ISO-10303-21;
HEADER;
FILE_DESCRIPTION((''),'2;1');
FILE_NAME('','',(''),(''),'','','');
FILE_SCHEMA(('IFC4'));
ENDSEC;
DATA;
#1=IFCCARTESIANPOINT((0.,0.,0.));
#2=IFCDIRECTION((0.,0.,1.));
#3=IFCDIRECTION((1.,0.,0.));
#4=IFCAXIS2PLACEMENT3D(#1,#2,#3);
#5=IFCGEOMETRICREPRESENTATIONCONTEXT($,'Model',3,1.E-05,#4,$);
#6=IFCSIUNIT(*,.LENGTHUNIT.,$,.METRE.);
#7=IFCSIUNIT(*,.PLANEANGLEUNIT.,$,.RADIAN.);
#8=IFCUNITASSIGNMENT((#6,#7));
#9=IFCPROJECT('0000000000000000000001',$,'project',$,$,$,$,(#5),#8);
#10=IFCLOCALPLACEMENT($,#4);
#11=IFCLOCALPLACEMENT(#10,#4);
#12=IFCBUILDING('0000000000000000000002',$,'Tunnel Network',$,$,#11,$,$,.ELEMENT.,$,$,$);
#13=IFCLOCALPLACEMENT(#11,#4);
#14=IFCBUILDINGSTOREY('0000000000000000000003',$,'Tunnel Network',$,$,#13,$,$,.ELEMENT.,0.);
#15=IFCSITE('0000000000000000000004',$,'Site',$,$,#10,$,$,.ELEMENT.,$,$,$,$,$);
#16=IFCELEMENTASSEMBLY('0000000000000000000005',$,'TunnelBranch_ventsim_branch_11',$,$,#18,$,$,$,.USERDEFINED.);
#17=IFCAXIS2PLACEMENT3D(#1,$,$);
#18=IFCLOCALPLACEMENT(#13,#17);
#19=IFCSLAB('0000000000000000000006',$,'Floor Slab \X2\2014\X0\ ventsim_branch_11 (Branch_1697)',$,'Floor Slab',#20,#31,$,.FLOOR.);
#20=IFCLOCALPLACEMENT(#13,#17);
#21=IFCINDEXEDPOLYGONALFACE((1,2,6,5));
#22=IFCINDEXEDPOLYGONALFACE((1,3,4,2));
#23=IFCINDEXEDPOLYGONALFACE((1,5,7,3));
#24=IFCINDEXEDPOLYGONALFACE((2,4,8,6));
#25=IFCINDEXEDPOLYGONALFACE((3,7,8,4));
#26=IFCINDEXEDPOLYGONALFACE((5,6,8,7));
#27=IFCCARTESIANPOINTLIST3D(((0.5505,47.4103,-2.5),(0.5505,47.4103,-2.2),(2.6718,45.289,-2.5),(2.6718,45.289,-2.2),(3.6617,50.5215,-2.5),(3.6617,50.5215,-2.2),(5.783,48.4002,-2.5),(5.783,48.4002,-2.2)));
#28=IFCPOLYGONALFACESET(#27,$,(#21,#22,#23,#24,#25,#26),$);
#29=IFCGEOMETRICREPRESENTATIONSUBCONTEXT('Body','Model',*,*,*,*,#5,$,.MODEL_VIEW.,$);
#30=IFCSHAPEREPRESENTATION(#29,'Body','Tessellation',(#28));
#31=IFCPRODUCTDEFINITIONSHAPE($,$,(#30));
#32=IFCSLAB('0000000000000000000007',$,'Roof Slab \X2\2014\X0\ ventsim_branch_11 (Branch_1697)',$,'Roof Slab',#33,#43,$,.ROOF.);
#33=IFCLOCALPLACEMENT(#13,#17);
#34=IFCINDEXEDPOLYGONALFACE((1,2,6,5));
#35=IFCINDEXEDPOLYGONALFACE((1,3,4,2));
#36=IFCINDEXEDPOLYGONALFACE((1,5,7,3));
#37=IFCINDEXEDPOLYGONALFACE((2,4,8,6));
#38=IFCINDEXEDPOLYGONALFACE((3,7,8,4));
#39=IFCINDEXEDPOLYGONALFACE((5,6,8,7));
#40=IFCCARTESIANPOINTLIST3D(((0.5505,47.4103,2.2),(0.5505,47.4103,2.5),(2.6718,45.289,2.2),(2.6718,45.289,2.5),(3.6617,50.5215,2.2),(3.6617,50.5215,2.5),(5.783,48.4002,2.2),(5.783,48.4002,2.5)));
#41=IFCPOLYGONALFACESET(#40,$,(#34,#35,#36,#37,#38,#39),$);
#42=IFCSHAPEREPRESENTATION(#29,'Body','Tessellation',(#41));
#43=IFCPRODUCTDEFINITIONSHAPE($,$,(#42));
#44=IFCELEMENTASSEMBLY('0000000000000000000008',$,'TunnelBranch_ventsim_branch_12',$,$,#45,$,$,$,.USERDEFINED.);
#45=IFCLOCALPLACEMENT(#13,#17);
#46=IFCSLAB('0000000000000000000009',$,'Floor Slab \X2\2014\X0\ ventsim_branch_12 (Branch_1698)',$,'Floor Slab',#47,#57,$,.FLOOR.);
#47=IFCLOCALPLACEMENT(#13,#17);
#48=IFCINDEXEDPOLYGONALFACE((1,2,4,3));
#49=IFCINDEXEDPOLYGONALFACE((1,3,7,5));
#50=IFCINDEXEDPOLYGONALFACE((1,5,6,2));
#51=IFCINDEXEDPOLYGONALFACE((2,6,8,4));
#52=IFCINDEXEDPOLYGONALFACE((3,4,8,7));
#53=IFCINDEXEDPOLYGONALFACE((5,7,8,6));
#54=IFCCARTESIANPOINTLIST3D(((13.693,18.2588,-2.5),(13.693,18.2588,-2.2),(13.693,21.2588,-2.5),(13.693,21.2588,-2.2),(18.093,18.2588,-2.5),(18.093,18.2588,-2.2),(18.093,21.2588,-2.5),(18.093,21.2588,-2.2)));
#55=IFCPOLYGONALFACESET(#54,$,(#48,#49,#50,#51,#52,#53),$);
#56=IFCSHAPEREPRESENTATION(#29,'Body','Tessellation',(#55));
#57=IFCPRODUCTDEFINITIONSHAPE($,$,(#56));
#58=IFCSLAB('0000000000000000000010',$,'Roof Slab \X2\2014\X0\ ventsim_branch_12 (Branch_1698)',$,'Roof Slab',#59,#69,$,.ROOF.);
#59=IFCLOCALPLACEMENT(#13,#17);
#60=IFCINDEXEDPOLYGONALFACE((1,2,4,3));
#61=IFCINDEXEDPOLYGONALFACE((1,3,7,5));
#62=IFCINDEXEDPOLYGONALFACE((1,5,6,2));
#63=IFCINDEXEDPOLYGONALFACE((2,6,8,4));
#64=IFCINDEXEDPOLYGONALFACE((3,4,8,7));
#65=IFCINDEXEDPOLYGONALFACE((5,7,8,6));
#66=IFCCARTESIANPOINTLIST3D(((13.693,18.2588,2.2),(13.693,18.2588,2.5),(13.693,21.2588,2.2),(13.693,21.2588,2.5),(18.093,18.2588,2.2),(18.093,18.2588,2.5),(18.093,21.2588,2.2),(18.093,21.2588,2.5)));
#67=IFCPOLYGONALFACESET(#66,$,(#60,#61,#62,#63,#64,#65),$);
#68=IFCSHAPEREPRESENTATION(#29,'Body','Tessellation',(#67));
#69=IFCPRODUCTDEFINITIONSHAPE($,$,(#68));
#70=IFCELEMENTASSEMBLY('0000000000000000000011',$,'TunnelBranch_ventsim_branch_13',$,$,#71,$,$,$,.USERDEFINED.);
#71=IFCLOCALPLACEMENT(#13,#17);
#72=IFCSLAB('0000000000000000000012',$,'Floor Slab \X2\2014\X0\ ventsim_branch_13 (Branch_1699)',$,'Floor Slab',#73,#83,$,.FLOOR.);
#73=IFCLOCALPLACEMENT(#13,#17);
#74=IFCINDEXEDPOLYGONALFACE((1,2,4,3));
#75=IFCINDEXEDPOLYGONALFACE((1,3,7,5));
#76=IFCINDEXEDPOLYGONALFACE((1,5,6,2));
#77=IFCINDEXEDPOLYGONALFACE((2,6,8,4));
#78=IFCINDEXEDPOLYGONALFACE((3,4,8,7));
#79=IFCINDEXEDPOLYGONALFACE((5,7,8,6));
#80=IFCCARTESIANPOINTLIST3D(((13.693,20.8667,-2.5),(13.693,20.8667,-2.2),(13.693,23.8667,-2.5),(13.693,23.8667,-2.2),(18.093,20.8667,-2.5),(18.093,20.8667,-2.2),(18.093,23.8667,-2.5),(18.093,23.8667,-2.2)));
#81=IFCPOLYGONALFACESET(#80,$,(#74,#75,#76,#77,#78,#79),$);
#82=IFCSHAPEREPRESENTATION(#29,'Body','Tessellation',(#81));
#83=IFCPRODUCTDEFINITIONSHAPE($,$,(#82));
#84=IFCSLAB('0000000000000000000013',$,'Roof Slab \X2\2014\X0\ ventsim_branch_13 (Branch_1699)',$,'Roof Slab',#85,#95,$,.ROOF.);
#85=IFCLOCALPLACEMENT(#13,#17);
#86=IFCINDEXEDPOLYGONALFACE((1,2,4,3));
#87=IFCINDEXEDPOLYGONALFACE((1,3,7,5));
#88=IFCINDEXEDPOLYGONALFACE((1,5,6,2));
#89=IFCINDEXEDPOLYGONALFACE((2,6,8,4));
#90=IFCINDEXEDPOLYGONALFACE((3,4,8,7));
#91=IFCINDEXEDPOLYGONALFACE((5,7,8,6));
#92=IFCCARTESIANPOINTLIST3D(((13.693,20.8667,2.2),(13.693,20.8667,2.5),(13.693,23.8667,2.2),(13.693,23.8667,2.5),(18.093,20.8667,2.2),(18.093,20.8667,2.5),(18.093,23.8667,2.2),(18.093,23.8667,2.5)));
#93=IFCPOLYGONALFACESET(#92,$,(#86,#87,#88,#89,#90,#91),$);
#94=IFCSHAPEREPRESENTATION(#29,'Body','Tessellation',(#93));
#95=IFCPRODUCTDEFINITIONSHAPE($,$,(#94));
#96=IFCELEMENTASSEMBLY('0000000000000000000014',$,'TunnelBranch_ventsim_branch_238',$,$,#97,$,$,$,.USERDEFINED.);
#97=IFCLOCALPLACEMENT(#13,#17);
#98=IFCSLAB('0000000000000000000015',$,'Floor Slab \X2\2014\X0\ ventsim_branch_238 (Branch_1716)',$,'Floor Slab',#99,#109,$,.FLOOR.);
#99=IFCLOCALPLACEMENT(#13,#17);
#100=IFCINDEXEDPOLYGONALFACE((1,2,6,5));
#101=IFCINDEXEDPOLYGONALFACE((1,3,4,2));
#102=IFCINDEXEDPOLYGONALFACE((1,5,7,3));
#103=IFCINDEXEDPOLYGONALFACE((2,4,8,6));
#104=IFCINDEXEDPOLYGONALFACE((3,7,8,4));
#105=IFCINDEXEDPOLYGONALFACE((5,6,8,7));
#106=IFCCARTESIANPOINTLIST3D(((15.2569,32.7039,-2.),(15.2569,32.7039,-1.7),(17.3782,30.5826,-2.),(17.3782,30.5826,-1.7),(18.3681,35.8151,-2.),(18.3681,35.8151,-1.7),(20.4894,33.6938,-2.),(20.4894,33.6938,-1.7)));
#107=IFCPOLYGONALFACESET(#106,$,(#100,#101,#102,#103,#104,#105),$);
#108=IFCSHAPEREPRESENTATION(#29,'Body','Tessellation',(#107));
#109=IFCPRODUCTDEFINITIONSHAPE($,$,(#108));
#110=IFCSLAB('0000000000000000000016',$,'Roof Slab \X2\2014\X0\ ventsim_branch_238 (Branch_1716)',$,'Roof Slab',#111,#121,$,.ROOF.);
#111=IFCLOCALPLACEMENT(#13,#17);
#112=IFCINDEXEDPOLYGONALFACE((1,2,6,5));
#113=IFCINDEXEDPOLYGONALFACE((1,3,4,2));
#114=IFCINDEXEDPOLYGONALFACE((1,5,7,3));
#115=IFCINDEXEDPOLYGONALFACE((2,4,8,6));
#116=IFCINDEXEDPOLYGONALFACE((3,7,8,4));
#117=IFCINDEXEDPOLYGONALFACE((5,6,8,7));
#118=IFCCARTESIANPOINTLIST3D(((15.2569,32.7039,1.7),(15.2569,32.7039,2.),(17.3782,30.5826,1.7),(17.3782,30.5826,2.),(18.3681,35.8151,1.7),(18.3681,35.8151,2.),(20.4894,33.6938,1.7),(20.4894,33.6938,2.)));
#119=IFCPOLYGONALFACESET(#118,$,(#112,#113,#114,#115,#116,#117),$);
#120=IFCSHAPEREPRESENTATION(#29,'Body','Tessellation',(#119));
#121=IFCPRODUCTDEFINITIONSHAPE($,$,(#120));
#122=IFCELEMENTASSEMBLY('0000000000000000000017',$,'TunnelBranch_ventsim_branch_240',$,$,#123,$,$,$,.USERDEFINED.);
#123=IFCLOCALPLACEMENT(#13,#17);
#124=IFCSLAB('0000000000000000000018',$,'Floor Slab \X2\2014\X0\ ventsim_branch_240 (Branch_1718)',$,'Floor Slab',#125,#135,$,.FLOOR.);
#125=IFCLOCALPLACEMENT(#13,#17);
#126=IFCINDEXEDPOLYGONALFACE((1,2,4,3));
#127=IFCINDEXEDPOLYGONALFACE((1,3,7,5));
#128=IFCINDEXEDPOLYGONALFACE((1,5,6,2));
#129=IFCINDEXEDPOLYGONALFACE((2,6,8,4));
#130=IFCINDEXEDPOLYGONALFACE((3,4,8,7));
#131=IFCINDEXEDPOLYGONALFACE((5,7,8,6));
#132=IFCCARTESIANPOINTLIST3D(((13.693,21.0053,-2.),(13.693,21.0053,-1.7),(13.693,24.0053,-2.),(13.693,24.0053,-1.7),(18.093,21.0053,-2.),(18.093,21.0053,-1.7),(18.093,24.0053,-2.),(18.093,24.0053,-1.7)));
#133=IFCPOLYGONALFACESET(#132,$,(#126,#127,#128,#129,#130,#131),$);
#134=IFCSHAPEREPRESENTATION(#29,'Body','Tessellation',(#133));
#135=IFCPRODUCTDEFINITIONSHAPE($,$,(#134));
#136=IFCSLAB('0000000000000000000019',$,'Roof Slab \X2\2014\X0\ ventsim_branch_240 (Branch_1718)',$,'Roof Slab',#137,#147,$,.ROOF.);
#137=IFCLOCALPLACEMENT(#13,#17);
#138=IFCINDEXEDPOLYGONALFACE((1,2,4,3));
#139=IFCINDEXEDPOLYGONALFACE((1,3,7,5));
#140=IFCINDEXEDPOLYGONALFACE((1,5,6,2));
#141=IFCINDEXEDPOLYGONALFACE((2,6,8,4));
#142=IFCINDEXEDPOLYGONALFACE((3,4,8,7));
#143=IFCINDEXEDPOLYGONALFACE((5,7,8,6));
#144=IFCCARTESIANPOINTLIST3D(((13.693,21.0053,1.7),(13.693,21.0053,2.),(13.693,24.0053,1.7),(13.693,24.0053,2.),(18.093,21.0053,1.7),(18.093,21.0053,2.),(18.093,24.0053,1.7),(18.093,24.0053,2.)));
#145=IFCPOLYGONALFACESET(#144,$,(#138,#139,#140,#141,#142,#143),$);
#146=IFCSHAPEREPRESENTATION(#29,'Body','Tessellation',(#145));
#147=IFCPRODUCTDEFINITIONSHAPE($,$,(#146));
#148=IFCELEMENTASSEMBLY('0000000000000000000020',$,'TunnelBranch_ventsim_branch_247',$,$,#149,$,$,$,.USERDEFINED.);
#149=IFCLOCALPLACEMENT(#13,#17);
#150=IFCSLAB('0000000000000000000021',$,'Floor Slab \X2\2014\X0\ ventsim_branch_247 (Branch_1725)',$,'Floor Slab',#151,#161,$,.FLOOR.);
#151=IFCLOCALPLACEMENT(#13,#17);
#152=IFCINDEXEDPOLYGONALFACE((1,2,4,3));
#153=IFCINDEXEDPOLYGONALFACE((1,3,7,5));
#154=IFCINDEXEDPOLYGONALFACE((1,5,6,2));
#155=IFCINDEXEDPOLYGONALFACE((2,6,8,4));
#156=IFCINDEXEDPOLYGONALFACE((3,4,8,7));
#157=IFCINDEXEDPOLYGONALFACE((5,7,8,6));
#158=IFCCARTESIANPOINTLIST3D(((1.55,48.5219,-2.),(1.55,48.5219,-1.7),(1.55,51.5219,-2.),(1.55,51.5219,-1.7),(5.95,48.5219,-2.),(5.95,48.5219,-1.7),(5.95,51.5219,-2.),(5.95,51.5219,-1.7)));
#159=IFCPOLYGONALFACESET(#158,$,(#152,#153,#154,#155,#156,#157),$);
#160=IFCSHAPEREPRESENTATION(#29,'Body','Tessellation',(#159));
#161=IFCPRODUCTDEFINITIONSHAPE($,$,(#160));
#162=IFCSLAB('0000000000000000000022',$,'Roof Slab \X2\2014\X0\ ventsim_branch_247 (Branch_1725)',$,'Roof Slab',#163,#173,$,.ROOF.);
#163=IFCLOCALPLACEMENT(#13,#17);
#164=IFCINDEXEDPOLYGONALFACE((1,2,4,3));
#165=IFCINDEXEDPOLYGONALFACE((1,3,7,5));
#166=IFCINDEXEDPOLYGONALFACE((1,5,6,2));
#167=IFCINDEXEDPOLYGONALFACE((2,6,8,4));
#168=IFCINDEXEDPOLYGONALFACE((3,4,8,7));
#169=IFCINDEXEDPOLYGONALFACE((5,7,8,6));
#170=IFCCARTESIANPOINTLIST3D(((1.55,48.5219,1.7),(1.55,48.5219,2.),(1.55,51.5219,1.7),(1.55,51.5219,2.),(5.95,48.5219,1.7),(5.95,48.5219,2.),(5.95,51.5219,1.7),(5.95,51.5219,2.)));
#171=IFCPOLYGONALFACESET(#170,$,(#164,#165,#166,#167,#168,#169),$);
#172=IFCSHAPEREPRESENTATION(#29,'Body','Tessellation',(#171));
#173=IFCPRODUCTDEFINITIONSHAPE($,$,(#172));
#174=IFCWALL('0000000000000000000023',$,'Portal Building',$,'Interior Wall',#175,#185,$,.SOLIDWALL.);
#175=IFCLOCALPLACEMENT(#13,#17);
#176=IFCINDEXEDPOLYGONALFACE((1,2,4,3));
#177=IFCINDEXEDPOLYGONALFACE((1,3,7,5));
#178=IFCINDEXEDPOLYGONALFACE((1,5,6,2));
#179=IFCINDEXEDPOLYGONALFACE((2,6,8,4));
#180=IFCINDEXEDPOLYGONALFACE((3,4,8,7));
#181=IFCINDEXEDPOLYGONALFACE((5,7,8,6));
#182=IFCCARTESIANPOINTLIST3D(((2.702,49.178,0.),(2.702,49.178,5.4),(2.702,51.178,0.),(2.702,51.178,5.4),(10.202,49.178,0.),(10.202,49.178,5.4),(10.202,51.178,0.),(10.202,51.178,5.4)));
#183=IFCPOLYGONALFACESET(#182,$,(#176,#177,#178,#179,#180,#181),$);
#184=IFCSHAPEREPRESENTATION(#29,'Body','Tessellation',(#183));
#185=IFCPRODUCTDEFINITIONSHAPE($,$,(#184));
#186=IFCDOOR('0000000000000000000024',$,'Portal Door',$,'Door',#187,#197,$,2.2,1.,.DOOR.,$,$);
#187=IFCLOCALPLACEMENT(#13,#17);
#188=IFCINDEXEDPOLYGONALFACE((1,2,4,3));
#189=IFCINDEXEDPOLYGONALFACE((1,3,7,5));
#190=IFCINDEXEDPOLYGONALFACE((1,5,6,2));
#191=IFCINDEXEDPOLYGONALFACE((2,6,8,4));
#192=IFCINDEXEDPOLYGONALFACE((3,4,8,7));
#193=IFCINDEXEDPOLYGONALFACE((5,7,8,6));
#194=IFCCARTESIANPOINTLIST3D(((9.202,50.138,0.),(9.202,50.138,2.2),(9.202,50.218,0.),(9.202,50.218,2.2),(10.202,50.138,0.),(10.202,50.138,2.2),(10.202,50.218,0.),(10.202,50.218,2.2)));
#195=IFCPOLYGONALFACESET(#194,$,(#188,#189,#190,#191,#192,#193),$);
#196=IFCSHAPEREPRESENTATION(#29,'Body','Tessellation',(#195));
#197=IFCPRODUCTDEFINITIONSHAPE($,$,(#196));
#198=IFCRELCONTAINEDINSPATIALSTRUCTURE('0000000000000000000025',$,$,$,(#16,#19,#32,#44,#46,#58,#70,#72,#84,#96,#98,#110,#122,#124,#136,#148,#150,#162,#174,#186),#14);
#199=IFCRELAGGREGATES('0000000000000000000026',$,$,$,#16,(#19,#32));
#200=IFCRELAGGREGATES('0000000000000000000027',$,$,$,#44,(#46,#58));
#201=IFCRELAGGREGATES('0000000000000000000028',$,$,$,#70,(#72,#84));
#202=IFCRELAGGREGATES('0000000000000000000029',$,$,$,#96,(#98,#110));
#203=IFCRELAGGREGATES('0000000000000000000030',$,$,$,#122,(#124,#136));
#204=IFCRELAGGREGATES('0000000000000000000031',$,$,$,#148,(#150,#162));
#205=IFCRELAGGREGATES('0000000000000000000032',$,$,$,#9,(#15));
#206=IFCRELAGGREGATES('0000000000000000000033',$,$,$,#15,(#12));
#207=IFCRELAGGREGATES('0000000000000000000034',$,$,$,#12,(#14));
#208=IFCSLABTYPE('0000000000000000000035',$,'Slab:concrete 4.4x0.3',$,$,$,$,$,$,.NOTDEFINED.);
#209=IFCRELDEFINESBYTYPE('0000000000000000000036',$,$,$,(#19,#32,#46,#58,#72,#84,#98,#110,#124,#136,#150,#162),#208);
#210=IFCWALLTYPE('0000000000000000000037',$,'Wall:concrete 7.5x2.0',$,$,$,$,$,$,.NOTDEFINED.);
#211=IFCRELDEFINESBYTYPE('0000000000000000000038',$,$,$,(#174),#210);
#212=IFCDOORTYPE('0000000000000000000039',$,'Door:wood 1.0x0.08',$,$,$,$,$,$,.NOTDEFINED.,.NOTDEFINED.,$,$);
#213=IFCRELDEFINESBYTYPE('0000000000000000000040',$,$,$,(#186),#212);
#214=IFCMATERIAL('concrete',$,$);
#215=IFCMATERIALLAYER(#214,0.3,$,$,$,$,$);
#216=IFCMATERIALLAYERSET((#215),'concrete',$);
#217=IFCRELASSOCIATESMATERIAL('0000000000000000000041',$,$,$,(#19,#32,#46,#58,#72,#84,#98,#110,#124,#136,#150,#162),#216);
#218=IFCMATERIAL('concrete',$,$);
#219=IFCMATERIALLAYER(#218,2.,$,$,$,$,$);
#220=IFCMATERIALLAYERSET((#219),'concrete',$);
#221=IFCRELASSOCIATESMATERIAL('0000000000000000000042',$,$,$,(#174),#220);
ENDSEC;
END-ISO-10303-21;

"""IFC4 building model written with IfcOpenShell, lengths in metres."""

from ifc_helpers import new_model, si_unit, frame, origin_with_axes, origin_2d_with_axis, place, context, subcontext, project, spatial, rectangle, extrude, material, layer, layer_set, layer_usage, type_object, element, aggregate, save


model = new_model("IFC4")

# Units and contexts
model_context = context("Model", 3, precision=1e-05, world=origin_with_axes())
body_context = subcontext(model_context, "Body", "Model", "MODEL_VIEW")
ifc_project = project(units=[si_unit("LENGTHUNIT", "METRE"), si_unit("PLANEANGLEUNIT", "RADIAN")], contexts=[model_context])

# Site, building, storey
site_placement = place(None, origin_with_axes())
site = spatial("IfcSite", under=ifc_project, at=site_placement, Name="Site", CompositionType="ELEMENT")
building_placement = place(site_placement, origin_with_axes())
building = spatial("IfcBuilding", under=site, at=building_placement, Name="Tunnel Network", CompositionType="ELEMENT")
storey_placement = place(building_placement, origin_with_axes())
storey = spatial("IfcBuildingStorey", under=building, at=storey_placement, Name="Tunnel Network", CompositionType="ELEMENT", Elevation=0.0)

# Element assemblies, slabs
assembly_1_placement = place(storey_placement, frame((3.8757, 50.5197, 0.0), z_axis=(0.707107, -0.707107, 0.0), x_axis=(-0.707107, -0.707107, 0.0)))
assembly_1 = element("IfcElementAssembly", 1, at=assembly_1_placement, inside=storey, Name="TunnelBranch_ventsim_branch_11", PredefinedType="USERDEFINED")
ifc_material_1 = material(Name="concrete")
ifc_layer_1 = layer(ifc_material_1, 0.3)
ifc_layer_set_1 = layer_set([ifc_layer_1], Name="concrete")
ifc_layer_usage_1 = layer_usage(ifc_layer_set_1, "AXIS3", "POSITIVE", 0.0)
slab_type = type_object("IfcSlabType", Name="Slab:concrete 4.4x0.3")
slab_1_placement = place(storey_placement, frame((2.1061, 48.9659, -2.35), z_axis=(0.707107, -0.707107, 0.0), x_axis=(-0.707107, -0.707107, 0.0)))
slab_1 = element("IfcSlab", 2, at=slab_1_placement, inside=storey, type_object=slab_type, material=ifc_layer_usage_1, Name="Floor Slab — ventsim_branch_11 (Branch_1697)", ObjectType="Floor Slab", PredefinedType="FLOOR", context=body_context, shape_type="SweptSolid", body=[
    extrude(rectangle(XDim=4.4, YDim=0.3, at=origin_2d_with_axis()), origin_with_axes(), (0.0, 0.0, 1.0), 3.0),
])
ifc_layer_usage_2 = layer_usage(ifc_layer_set_1, "AXIS3", "POSITIVE", 0.0)
slab_2_placement = place(storey_placement, frame((2.1061, 48.9659, 2.35), z_axis=(0.707107, -0.707107, 0.0), x_axis=(-0.707107, -0.707107, 0.0)))
slab_2 = element("IfcSlab", 3, at=slab_2_placement, inside=storey, type_object=slab_type, material=ifc_layer_usage_2, Name="Roof Slab — ventsim_branch_11 (Branch_1697)", ObjectType="Roof Slab", PredefinedType="ROOF", context=body_context, shape_type="SweptSolid", body=[
    extrude(rectangle(XDim=4.4, YDim=0.3, at=origin_2d_with_axis()), origin_with_axes(), (0.0, 0.0, 1.0), 3.0),
])
assembly_2_placement = place(storey_placement, frame((13.543, 18.2588, 0.0), z_axis=(0.0, 1.0, 0.0), x_axis=(1.0, 0.0, 0.0)))
assembly_2 = element("IfcElementAssembly", 4, at=assembly_2_placement, inside=storey, Name="TunnelBranch_ventsim_branch_12", PredefinedType="USERDEFINED")
ifc_layer_usage_3 = layer_usage(ifc_layer_set_1, "AXIS3", "POSITIVE", 0.0)
slab_3_placement = place(storey_placement, frame((15.893, 18.2588, -2.35), z_axis=(0.0, 1.0, 0.0), x_axis=(1.0, 0.0, 0.0)))
slab_3 = element("IfcSlab", 5, at=slab_3_placement, inside=storey, type_object=slab_type, material=ifc_layer_usage_3, Name="Floor Slab — ventsim_branch_12 (Branch_1698)", ObjectType="Floor Slab", PredefinedType="FLOOR", context=body_context, shape_type="SweptSolid", body=[
    extrude(rectangle(XDim=4.4, YDim=0.3, at=origin_2d_with_axis()), origin_with_axes(), (0.0, 0.0, 1.0), 3.0),
])
ifc_layer_usage_4 = layer_usage(ifc_layer_set_1, "AXIS3", "POSITIVE", 0.0)
slab_4_placement = place(storey_placement, frame((15.893, 18.2588, 2.35), z_axis=(0.0, 1.0, 0.0), x_axis=(1.0, 0.0, 0.0)))
slab_4 = element("IfcSlab", 6, at=slab_4_placement, inside=storey, type_object=slab_type, material=ifc_layer_usage_4, Name="Roof Slab — ventsim_branch_12 (Branch_1698)", ObjectType="Roof Slab", PredefinedType="ROOF", context=body_context, shape_type="SweptSolid", body=[
    extrude(rectangle(XDim=4.4, YDim=0.3, at=origin_2d_with_axis()), origin_with_axes(), (0.0, 0.0, 1.0), 3.0),
])
assembly_3_placement = place(storey_placement, frame((13.543, 20.8667, 0.0), z_axis=(0.0, 1.0, 0.0), x_axis=(1.0, 0.0, 0.0)))
assembly_3 = element("IfcElementAssembly", 7, at=assembly_3_placement, inside=storey, Name="TunnelBranch_ventsim_branch_13", PredefinedType="USERDEFINED")
ifc_layer_usage_5 = layer_usage(ifc_layer_set_1, "AXIS3", "POSITIVE", 0.0)
slab_5_placement = place(storey_placement, frame((15.893, 20.8667, -2.35), z_axis=(0.0, 1.0, 0.0), x_axis=(1.0, 0.0, 0.0)))
slab_5 = element("IfcSlab", 8, at=slab_5_placement, inside=storey, type_object=slab_type, material=ifc_layer_usage_5, Name="Floor Slab — ventsim_branch_13 (Branch_1699)", ObjectType="Floor Slab", PredefinedType="FLOOR", context=body_context, shape_type="SweptSolid", body=[
    extrude(rectangle(XDim=4.4, YDim=0.3, at=origin_2d_with_axis()), origin_with_axes(), (0.0, 0.0, 1.0), 3.0),
])
ifc_layer_usage_6 = layer_usage(ifc_layer_set_1, "AXIS3", "POSITIVE", 0.0)
slab_6_placement = place(storey_placement, frame((15.893, 20.8667, 2.35), z_axis=(0.0, 1.0, 0.0), x_axis=(1.0, 0.0, 0.0)))
slab_6 = element("IfcSlab", 9, at=slab_6_placement, inside=storey, type_object=slab_type, material=ifc_layer_usage_6, Name="Roof Slab — ventsim_branch_13 (Branch_1699)", ObjectType="Roof Slab", PredefinedType="ROOF", context=body_context, shape_type="SweptSolid", body=[
    extrude(rectangle(XDim=4.4, YDim=0.3, at=origin_2d_with_axis()), origin_with_axes(), (0.0, 0.0, 1.0), 3.0),
])
assembly_4_placement = place(storey_placement, frame((16.8148, 30.9338, 0.0), z_axis=(-0.707107, 0.707107, 0.0), x_axis=(0.707107, 0.707107, 0.0)))
assembly_4 = element("IfcElementAssembly", 10, at=assembly_4_placement, inside=storey, Name="TunnelBranch_ventsim_branch_238", PredefinedType="USERDEFINED")
ifc_layer_usage_7 = layer_usage(ifc_layer_set_1, "AXIS3", "POSITIVE", 0.0)
slab_7_placement = place(storey_placement, frame((18.9338, 32.1382, -1.85), z_axis=(-0.707107, 0.707107, 0.0), x_axis=(0.707107, 0.707107, 0.0)))
slab_7 = element("IfcSlab", 11, at=slab_7_placement, inside=storey, type_object=slab_type, material=ifc_layer_usage_7, Name="Floor Slab — ventsim_branch_238 (Branch_1716)", ObjectType="Floor Slab", PredefinedType="FLOOR", context=body_context, shape_type="SweptSolid", body=[
    extrude(rectangle(XDim=4.4, YDim=0.3, at=origin_2d_with_axis()), origin_with_axes(), (0.0, 0.0, 1.0), 3.0),
])
ifc_layer_usage_8 = layer_usage(ifc_layer_set_1, "AXIS3", "POSITIVE", 0.0)
slab_8_placement = place(storey_placement, frame((18.9338, 32.1382, 1.85), z_axis=(-0.707107, 0.707107, 0.0), x_axis=(0.707107, 0.707107, 0.0)))
slab_8 = element("IfcSlab", 12, at=slab_8_placement, inside=storey, type_object=slab_type, material=ifc_layer_usage_8, Name="Roof Slab — ventsim_branch_238 (Branch_1716)", ObjectType="Roof Slab", PredefinedType="ROOF", context=body_context, shape_type="SweptSolid", body=[
    extrude(rectangle(XDim=4.4, YDim=0.3, at=origin_2d_with_axis()), origin_with_axes(), (0.0, 0.0, 1.0), 3.0),
])
assembly_5_placement = place(storey_placement, frame((13.543, 20.8667, 0.0), z_axis=(0.0, 1.0, 0.0), x_axis=(1.0, 0.0, 0.0)))
assembly_5 = element("IfcElementAssembly", 13, at=assembly_5_placement, inside=storey, Name="TunnelBranch_ventsim_branch_240", PredefinedType="USERDEFINED")
ifc_layer_usage_9 = layer_usage(ifc_layer_set_1, "AXIS3", "POSITIVE", 0.0)
slab_9_placement = place(storey_placement, frame((15.893, 21.0053, -1.85), z_axis=(0.0, 1.0, 0.0), x_axis=(1.0, 0.0, 0.0)))
slab_9 = element("IfcSlab", 14, at=slab_9_placement, inside=storey, type_object=slab_type, material=ifc_layer_usage_9, Name="Floor Slab — ventsim_branch_240 (Branch_1718)", ObjectType="Floor Slab", PredefinedType="FLOOR", context=body_context, shape_type="SweptSolid", body=[
    extrude(rectangle(XDim=4.4, YDim=0.3, at=origin_2d_with_axis()), origin_with_axes(), (0.0, 0.0, 1.0), 3.0),
])
ifc_layer_usage_10 = layer_usage(ifc_layer_set_1, "AXIS3", "POSITIVE", 0.0)
slab_10_placement = place(storey_placement, frame((15.893, 21.0053, 1.85), z_axis=(0.0, 1.0, 0.0), x_axis=(1.0, 0.0, 0.0)))
slab_10 = element("IfcSlab", 15, at=slab_10_placement, inside=storey, type_object=slab_type, material=ifc_layer_usage_10, Name="Roof Slab — ventsim_branch_240 (Branch_1718)", ObjectType="Roof Slab", PredefinedType="ROOF", context=body_context, shape_type="SweptSolid", body=[
    extrude(rectangle(XDim=4.4, YDim=0.3, at=origin_2d_with_axis()), origin_with_axes(), (0.0, 0.0, 1.0), 3.0),
])
assembly_6_placement = place(storey_placement, frame((1.4, 48.5219, 0.0), z_axis=(0.0, 1.0, 0.0), x_axis=(1.0, 0.0, 0.0)))
assembly_6 = element("IfcElementAssembly", 16, at=assembly_6_placement, inside=storey, Name="TunnelBranch_ventsim_branch_247", PredefinedType="USERDEFINED")
ifc_layer_usage_11 = layer_usage(ifc_layer_set_1, "AXIS3", "POSITIVE", 0.0)
slab_11_placement = place(storey_placement, frame((3.75, 48.5219, -1.85), z_axis=(0.0, 1.0, 0.0), x_axis=(1.0, 0.0, 0.0)))
slab_11 = element("IfcSlab", 17, at=slab_11_placement, inside=storey, type_object=slab_type, material=ifc_layer_usage_11, Name="Floor Slab — ventsim_branch_247 (Branch_1725)", ObjectType="Floor Slab", PredefinedType="FLOOR", context=body_context, shape_type="SweptSolid", body=[
    extrude(rectangle(XDim=4.4, YDim=0.3, at=origin_2d_with_axis()), origin_with_axes(), (0.0, 0.0, 1.0), 3.0),
])
ifc_layer_usage_12 = layer_usage(ifc_layer_set_1, "AXIS3", "POSITIVE", 0.0)
slab_12_placement = place(storey_placement, frame((3.75, 48.5219, 1.85), z_axis=(0.0, 1.0, 0.0), x_axis=(1.0, 0.0, 0.0)))
slab_12 = element("IfcSlab", 18, at=slab_12_placement, inside=storey, type_object=slab_type, material=ifc_layer_usage_12, Name="Roof Slab — ventsim_branch_247 (Branch_1725)", ObjectType="Roof Slab", PredefinedType="ROOF", context=body_context, shape_type="SweptSolid", body=[
    extrude(rectangle(XDim=4.4, YDim=0.3, at=origin_2d_with_axis()), origin_with_axes(), (0.0, 0.0, 1.0), 3.0),
])

# Wall
ifc_material_2 = material(Name="concrete")
ifc_layer_2 = layer(ifc_material_2, 2.0)
ifc_layer_set_2 = layer_set([ifc_layer_2], Name="concrete")
ifc_layer_usage_13 = layer_usage(ifc_layer_set_2, "AXIS2", "POSITIVE", 0.0)
wall_type_1 = type_object("IfcWallType", Name="Wall:concrete 7.5x2.0")
wall_1_placement = place(storey_placement, frame((6.452, 50.178, 0.0), z_axis=(0.0, 0.0, 1.0), x_axis=(1.0, 0.0, 0.0)))
element("IfcWall", 19, at=wall_1_placement, inside=storey, type_object=wall_type_1, material=ifc_layer_usage_13, Name="Portal Building", ObjectType="Interior Wall", PredefinedType="SOLIDWALL", context=body_context, shape_type="SweptSolid", body=[
    extrude(rectangle(XDim=7.5, YDim=2.0, at=origin_2d_with_axis()), origin_with_axes(), (0.0, 0.0, 1.0), 5.4),
])

# Door
door_type = type_object("IfcDoorType", Name="Door:wood 1.0x0.08")
door_placement = place(storey_placement, frame((9.702, 50.178, 0.0), z_axis=(0.0, 0.0, 1.0), x_axis=(1.0, 0.0, 0.0)))
element("IfcDoor", 20, at=door_placement, inside=storey, type_object=door_type, Name="Portal Door", ObjectType="Door", OverallHeight=2.2, OverallWidth=1.0, PredefinedType="DOOR", context=body_context, shape_type="SweptSolid", body=[
    extrude(rectangle(XDim=1.0, YDim=0.08, at=origin_2d_with_axis()), origin_with_axes(), (0.0, 0.0, 1.0), 2.2),
])

aggregate(assembly_1, [slab_1, slab_2])
aggregate(assembly_2, [slab_3, slab_4])
aggregate(assembly_3, [slab_5, slab_6])
aggregate(assembly_4, [slab_7, slab_8])
aggregate(assembly_5, [slab_9, slab_10])
aggregate(assembly_6, [slab_11, slab_12])

save(model, "model.ifc")
